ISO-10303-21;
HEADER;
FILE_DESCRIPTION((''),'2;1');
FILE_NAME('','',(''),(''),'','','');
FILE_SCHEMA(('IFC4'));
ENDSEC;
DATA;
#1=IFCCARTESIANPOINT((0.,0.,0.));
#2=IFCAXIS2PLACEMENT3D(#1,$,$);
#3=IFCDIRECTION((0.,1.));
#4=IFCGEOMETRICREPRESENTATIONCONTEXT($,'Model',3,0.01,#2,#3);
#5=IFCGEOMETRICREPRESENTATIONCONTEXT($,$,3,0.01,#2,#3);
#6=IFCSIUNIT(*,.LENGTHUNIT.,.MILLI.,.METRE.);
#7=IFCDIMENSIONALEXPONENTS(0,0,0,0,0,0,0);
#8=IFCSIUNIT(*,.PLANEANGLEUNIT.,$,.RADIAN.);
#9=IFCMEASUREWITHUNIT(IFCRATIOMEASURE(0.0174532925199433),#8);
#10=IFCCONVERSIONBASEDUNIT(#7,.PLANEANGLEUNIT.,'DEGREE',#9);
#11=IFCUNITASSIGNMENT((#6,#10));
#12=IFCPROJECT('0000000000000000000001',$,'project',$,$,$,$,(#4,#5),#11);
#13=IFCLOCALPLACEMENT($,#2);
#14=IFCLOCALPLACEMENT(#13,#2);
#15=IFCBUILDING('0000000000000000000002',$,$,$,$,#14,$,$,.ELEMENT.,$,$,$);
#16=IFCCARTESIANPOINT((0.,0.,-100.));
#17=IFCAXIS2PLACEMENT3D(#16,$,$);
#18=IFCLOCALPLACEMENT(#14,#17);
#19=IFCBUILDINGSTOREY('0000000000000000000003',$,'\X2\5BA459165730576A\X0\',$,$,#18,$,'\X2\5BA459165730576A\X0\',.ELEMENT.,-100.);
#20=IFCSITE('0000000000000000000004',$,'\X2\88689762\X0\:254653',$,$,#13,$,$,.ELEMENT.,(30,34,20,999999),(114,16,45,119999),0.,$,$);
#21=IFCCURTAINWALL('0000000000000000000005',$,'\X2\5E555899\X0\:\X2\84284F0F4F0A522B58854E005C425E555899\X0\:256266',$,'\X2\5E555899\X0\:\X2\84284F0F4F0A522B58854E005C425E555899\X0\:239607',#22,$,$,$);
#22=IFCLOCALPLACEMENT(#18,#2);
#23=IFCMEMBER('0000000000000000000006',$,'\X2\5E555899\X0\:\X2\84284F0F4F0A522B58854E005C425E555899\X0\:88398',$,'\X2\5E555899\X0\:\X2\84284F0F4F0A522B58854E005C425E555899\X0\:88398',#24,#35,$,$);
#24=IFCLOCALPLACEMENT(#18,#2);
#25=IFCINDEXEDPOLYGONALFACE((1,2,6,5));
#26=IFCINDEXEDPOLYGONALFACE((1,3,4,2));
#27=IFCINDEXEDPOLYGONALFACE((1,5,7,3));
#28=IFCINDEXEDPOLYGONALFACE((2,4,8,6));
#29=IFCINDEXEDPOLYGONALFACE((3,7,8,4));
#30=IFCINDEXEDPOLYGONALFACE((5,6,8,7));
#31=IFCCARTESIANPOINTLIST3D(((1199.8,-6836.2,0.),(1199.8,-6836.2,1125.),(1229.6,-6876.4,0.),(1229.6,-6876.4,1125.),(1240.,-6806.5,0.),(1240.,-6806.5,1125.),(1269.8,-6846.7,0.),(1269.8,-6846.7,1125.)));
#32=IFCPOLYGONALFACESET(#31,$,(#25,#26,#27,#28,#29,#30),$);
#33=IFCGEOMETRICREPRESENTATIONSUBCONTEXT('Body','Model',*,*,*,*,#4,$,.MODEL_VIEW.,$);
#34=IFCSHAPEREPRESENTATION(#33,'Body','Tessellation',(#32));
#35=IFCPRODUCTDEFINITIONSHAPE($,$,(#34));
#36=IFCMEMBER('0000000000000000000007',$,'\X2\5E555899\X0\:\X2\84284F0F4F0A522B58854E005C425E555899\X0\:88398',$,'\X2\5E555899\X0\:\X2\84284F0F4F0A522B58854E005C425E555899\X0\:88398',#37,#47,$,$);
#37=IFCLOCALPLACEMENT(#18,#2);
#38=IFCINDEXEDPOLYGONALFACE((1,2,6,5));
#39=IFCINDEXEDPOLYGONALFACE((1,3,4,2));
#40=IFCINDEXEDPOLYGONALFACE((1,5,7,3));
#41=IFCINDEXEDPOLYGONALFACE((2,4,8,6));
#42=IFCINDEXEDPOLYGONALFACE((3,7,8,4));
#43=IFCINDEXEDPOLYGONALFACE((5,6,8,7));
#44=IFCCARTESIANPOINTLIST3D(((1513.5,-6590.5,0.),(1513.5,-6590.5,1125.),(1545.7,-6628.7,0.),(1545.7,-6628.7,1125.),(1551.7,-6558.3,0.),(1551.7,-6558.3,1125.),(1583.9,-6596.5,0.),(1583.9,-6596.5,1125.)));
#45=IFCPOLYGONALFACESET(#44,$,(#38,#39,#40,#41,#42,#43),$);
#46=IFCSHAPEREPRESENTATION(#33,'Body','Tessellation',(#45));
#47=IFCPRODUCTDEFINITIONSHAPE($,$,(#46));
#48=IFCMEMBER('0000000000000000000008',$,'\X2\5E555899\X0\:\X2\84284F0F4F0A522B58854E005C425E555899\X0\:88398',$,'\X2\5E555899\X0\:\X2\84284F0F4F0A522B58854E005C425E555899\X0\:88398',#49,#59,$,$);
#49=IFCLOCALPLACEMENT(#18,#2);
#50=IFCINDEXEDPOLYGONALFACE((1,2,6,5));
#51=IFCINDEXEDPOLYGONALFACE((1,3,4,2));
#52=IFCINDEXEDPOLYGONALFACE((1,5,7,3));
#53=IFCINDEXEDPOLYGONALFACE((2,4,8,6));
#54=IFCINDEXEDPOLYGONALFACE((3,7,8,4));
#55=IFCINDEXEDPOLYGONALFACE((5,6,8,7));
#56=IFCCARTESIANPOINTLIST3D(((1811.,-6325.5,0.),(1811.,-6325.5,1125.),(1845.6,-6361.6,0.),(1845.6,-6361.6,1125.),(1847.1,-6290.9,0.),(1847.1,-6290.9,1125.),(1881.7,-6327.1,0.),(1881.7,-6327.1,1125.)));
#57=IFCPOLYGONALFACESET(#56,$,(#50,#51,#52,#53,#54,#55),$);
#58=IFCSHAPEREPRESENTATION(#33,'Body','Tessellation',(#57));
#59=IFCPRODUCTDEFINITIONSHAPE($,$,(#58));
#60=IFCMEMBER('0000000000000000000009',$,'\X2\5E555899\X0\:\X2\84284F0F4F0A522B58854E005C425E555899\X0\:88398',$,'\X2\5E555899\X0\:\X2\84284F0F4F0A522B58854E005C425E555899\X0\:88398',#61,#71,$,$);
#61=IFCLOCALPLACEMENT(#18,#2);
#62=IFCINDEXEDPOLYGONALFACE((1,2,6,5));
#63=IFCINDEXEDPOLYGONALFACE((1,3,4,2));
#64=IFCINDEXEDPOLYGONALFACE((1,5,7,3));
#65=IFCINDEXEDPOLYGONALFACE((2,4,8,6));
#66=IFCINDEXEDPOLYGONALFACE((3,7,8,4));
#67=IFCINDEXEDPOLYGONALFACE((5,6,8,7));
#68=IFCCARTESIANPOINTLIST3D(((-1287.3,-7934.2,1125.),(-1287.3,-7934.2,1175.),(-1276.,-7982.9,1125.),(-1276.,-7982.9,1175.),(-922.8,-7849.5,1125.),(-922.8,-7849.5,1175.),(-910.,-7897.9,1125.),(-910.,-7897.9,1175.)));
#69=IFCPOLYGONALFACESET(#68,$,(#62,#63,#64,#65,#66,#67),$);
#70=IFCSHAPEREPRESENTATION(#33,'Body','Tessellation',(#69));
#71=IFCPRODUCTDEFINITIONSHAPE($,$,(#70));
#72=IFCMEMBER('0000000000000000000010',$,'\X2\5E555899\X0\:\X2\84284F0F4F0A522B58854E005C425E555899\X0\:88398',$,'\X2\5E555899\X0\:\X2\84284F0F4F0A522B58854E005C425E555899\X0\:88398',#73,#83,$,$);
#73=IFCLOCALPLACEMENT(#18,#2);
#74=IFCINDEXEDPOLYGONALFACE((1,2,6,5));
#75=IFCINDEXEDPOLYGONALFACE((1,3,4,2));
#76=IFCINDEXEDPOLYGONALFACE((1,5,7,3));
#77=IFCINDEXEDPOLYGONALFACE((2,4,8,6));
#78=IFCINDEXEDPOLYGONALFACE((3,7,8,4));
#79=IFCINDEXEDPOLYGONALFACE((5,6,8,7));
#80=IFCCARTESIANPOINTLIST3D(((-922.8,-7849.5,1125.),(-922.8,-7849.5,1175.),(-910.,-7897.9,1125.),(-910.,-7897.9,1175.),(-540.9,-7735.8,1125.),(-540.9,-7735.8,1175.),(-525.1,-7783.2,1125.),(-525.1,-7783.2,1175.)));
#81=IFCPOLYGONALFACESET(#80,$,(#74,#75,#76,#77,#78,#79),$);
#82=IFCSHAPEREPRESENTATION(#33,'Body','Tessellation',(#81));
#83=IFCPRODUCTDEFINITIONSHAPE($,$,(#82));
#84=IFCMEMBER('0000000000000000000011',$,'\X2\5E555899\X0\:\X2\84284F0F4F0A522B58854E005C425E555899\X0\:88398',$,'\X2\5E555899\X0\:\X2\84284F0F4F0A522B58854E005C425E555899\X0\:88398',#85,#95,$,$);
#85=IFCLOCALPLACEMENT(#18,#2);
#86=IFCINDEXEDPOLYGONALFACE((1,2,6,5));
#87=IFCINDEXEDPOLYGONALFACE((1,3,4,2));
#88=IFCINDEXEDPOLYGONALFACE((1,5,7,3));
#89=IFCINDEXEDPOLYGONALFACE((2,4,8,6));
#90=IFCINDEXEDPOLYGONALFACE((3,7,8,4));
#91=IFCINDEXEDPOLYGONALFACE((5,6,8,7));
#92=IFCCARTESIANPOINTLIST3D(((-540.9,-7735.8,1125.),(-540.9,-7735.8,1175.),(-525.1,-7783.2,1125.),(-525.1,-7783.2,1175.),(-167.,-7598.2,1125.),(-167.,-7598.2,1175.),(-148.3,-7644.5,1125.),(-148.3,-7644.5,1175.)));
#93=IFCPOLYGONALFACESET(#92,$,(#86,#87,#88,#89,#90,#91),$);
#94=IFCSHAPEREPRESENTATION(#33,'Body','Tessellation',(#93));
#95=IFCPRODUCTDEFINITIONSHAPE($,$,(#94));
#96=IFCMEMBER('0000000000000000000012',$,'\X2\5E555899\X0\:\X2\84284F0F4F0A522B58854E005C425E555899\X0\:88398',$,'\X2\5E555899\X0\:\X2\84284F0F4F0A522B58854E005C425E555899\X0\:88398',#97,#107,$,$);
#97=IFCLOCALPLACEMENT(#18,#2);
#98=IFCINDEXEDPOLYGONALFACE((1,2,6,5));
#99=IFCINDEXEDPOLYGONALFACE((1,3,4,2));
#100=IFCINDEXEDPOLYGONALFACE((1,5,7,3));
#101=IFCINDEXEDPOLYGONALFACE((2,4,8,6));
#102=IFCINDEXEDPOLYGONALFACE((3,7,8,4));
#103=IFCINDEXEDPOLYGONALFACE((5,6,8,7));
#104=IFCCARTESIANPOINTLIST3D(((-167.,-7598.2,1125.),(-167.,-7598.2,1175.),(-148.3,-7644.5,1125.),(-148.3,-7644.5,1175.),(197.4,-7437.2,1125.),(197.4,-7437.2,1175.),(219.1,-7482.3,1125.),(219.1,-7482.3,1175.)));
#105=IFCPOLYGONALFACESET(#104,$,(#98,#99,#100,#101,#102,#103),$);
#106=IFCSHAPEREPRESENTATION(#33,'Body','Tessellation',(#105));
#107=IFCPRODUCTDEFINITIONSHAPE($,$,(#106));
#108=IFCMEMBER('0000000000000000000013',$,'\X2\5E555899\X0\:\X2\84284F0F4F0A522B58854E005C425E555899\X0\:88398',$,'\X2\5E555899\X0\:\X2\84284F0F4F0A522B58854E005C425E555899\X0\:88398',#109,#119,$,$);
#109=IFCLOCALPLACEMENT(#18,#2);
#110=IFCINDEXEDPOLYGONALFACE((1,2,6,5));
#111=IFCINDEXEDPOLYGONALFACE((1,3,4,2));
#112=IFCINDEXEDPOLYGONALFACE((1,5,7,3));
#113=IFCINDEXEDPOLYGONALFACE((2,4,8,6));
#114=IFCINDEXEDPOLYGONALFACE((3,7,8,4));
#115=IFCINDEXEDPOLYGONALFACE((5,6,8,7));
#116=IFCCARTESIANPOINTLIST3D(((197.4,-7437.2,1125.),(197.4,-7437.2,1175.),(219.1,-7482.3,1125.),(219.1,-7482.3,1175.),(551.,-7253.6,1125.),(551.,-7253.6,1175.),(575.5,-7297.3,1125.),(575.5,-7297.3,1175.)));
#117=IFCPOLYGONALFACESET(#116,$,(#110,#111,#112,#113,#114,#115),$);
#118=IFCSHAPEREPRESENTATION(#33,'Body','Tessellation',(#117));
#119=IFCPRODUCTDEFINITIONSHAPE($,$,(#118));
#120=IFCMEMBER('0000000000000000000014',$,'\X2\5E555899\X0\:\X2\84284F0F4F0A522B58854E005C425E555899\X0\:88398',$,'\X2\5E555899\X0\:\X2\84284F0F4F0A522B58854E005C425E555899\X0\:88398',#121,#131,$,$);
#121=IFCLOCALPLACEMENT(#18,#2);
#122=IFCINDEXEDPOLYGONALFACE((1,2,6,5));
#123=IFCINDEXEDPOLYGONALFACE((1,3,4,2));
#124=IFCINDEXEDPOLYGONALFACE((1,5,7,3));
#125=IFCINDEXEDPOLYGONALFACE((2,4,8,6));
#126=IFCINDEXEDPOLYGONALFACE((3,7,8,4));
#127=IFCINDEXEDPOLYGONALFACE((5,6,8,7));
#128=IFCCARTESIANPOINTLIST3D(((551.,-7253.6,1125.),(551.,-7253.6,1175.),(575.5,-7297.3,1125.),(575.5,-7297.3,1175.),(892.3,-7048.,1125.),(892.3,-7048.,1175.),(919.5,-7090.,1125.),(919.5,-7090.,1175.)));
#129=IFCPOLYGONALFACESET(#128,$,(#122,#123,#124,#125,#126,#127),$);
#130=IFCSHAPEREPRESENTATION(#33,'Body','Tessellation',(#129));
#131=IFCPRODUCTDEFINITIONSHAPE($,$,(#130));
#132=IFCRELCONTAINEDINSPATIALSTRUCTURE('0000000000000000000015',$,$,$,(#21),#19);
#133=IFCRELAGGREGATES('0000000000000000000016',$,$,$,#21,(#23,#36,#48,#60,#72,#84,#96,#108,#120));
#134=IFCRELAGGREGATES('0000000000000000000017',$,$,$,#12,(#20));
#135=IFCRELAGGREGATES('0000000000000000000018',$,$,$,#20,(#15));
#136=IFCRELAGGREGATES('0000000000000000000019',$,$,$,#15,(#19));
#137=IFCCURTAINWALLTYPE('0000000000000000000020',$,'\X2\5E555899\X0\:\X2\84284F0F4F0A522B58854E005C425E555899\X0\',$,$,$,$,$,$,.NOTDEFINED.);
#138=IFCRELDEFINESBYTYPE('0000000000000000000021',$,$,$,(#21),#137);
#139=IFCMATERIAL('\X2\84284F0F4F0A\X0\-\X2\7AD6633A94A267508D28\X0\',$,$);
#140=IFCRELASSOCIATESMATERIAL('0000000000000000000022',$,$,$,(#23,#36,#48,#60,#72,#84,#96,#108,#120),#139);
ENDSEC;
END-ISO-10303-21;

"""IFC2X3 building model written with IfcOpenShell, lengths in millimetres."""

from ifc_helpers import new_model, entity, si_unit, converted_unit, direction, frame, frame_2d, origin, origin_2d_with_axis, place, context, subcontext, project, spatial, rectangle, extrude, clip, halfspace, material, type_object, element, aggregate, save


model = new_model("IFC2X3")

# Units and contexts
model_context = context("Model", 3, precision=0.01, world=origin(), true_north=direction((0.0, 1.0)))
context_of_model = context(None, 3, precision=0.01, world=origin(), true_north=direction((0.0, 1.0)))
body_context = subcontext(model_context, "Body", "Model", "MODEL_VIEW")
ifc_project = project(units=[si_unit("LENGTHUNIT", "METRE", prefix="MILLI"), converted_unit("PLANEANGLEUNIT", "DEGREE", entity("IfcRatioMeasure", 0.0174532925199433), si_unit("PLANEANGLEUNIT", "RADIAN"), dimensions=[0, 0, 0, 0, 0, 0, 0])], contexts=[model_context, context_of_model])

# Site, building, storey
site_placement = place(None, origin())
site = spatial("IfcSite", under=ifc_project, at=site_placement, Name="表面:254653", CompositionType="ELEMENT", RefLatitude=(30, 34, 20, 999999), RefLongitude=(114, 16, 45, 119999), RefElevation=0.0)
building_placement = place(site_placement, origin())
building = spatial("IfcBuilding", under=site, at=building_placement, CompositionType="ELEMENT")
storey_placement = place(building_placement, frame((0.0, 0.0, -100.0)))
storey = spatial("IfcBuildingStorey", under=building, at=storey_placement, Name="室外地坪", LongName="室外地坪", CompositionType="ELEMENT", Elevation=-100.0)

# Curtain wall, members
curtain_wall_type = type_object("IfcCurtainWallType", Name="幕墙:萨伏伊别墅一层幕墙", PredefinedType="NOTDEFINED")
curtain_wall_placement = place(storey_placement, frame((0.0, 0.0, 100.0)))
curtain_wall = element("IfcCurtainWall", 1, at=curtain_wall_placement, inside=storey, type_object=curtain_wall_type, Name="幕墙:萨伏伊别墅一层幕墙:256266", ObjectType="幕墙:萨伏伊别墅一层幕墙:239607")
ifc_material_1 = material(Name="萨伏伊-竖挺钢材质")
member_1_placement = place(curtain_wall_placement, origin())
member_1 = element("IfcMember", 2, at=member_1_placement, material=ifc_material_1, Name="幕墙:萨伏伊别墅一层幕墙:88398", ObjectType="幕墙:萨伏伊别墅一层幕墙:88398", context=body_context, shape_type="SweptSolid", body=[
    extrude(rectangle(XDim=50.0, YDim=50.0, at=frame_2d((0.0, 0.0), x_axis=(1.0, 0.0))), frame((1234.8, -6841.4, -100.0), z_axis=(0.0, 0.0, 1.0), x_axis=(0.803942, 0.594708, 0.0)), (0.0, 0.0, 1.0), 1125.0),
])
member_2_placement = place(curtain_wall_placement, origin())
member_2 = element("IfcMember", 3, at=member_2_placement, material=ifc_material_1, Name="幕墙:萨伏伊别墅一层幕墙:88398", ObjectType="幕墙:萨伏伊别墅一层幕墙:88398", context=body_context, shape_type="SweptSolid", body=[
    extrude(rectangle(XDim=50.0, YDim=50.0, at=origin_2d_with_axis()), frame((1548.7, -6593.5, -100.0), z_axis=(0.0, 0.0, 1.0), x_axis=(0.764797, 0.644272, 0.0)), (0.0, 0.0, 1.0), 1125.0),
])
member_3_placement = place(curtain_wall_placement, origin())
member_3 = element("IfcMember", 4, at=member_3_placement, material=ifc_material_1, Name="幕墙:萨伏伊别墅一层幕墙:88398", ObjectType="幕墙:萨伏伊别墅一层幕墙:88398", context=body_context, shape_type="SweptSolid", body=[
    extrude(rectangle(XDim=50.0, YDim=50.0, at=frame_2d((0.0, 0.0), x_axis=(1.0, 0.0))), frame((1846.3, -6326.3, -100.0), z_axis=(0.0, 0.0, 1.0), x_axis=(0.722601, 0.691266, 0.0)), (0.0, 0.0, 1.0), 1125.0),
])
member_4_placement = place(curtain_wall_placement, frame((0.0, 0.0, -100.0)))
member_4 = element("IfcMember", 5, at=member_4_placement, material=ifc_material_1, Name="幕墙:萨伏伊别墅一层幕墙:88398", ObjectType="幕墙:萨伏伊别墅一层幕墙:88398", context=body_context, shape_type="Clipping", body=[
    clip(extrude(rectangle(XDim=50.0, YDim=50.0, at=origin_2d_with_axis()), frame((-915.7, -7873.5, 1150.0), z_axis=(-0.974057, -0.226305, 0.0), x_axis=(0.0, 0.0, -1.0)), (0.0, 0.0, 1.0), 375.8), halfspace(frame((-916.4, -7873.7, 1454.8), z_axis=(0.966677, 0.255997, 0.0), x_axis=(0.255997, -0.966677, 0.0)), False)),
])
member_5_placement = place(curtain_wall_placement, frame((0.0, 0.0, -100.0)))
member_5 = element("IfcMember", 6, at=member_5_placement, material=ifc_material_1, Name="幕墙:萨伏伊别墅一层幕墙:88398", ObjectType="幕墙:萨伏伊别墅一层幕墙:88398", context=body_context, shape_type="Clipping", body=[
    clip(clip(extrude(rectangle(XDim=50.0, YDim=50.0, at=frame_2d((0.0, 0.0), x_axis=(1.0, 0.0))), frame((-532.3, -7759.3, 1150.0), z_axis=(-0.958394, -0.28545, 0.0), x_axis=(0.0, 0.0, -1.0)), (0.0, 0.0, 1.0), 401.6), halfspace(frame((-533.0, -7759.5, 1454.8), z_axis=(0.948901, 0.315573, 0.0), x_axis=(0.315573, -0.948901, 0.0)), False)), halfspace(frame((-916.4, -7873.7, 1454.8), z_axis=(-0.966677, -0.255997, 0.0), x_axis=(0.255997, -0.966677, 0.0)), False)),
])
member_6_placement = place(curtain_wall_placement, frame((0.0, 0.0, -100.0)))
member_6 = element("IfcMember", 7, at=member_6_placement, material=ifc_material_1, Name="幕墙:萨伏伊别墅一层幕墙:88398", ObjectType="幕墙:萨伏伊别墅一层幕墙:88398", context=body_context, shape_type="Clipping", body=[
    clip(clip(extrude(rectangle(XDim=50.0, YDim=50.0, at=frame_2d((0.0, 0.0), x_axis=(1.0, 0.0))), frame((-156.9, -7621.1, 1150.0), z_axis=(-0.938463, -0.345381, 0.0), x_axis=(0.0, 0.0, -1.0)), (0.0, 0.0, 1.0), 401.6), halfspace(frame((-157.7, -7621.4, 1454.8), z_axis=(0.927088, 0.374844, 0.0), x_axis=(0.374844, -0.927088, 0.0)), False)), halfspace(frame((-533.0, -7759.5, 1454.8), z_axis=(-0.948901, -0.315573, 0.0), x_axis=(0.315573, -0.948901, 0.0)), False)),
])
member_7_placement = place(curtain_wall_placement, frame((0.0, 0.0, -100.0)))
member_7 = element("IfcMember", 8, at=member_7_placement, material=ifc_material_1, Name="幕墙:萨伏伊别墅一层幕墙:88398", ObjectType="幕墙:萨伏伊别墅一层幕墙:88398", context=body_context, shape_type="Clipping", body=[
    clip(clip(extrude(rectangle(XDim=50.0, YDim=50.0, at=frame_2d((0.0, 0.0), x_axis=(1.0, 0.0))), frame((209.0, -7459.5, 1150.0), z_axis=(-0.914788, -0.403934, 0.0), x_axis=(0.0, 0.0, -1.0)), (0.0, 0.0, 1.0), 401.6), halfspace(frame((208.3, -7459.8, 1454.8), z_axis=(0.901576, 0.43262, 0.0), x_axis=(0.43262, -0.901576, 0.0)), False)), halfspace(frame((-157.7, -7621.4, 1454.8), z_axis=(-0.927088, -0.374844, 0.0), x_axis=(0.374844, -0.927088, 0.0)), False)),
])
member_8_placement = place(curtain_wall_placement, frame((0.0, 0.0, -100.0)))
member_8 = element("IfcMember", 9, at=member_8_placement, material=ifc_material_1, Name="幕墙:萨伏伊别墅一层幕墙:88398", ObjectType="幕墙:萨伏伊别墅一层幕墙:88398", context=body_context, shape_type="Clipping", body=[
    clip(clip(extrude(rectangle(XDim=50.0, YDim=50.0, at=frame_2d((0.0, 0.0), x_axis=(1.0, 0.0))), frame((563.9, -7275.1, 1150.0), z_axis=(-0.887465, -0.460875, 0.0), x_axis=(0.0, 0.0, -1.0)), (0.0, 0.0, 1.0), 401.6), halfspace(frame((563.2, -7275.4, 1454.8), z_axis=(0.872468, 0.488671, 0.0), x_axis=(0.488671, -0.872468, 0.0)), False)), halfspace(frame((208.3, -7459.8, 1454.8), z_axis=(-0.901576, -0.43262, 0.0), x_axis=(0.43262, -0.901576, 0.0)), False)),
])
member_9_placement = place(curtain_wall_placement, frame((0.0, 0.0, -100.0)))
member_9 = element("IfcMember", 10, at=member_9_placement, material=ifc_material_1, Name="幕墙:萨伏伊别墅一层幕墙:88398", ObjectType="幕墙:萨伏伊别墅一层幕墙:88398", context=body_context, shape_type="Clipping", body=[
    clip(clip(extrude(rectangle(XDim=50.0, YDim=50.0, at=origin_2d_with_axis()), frame((906.6, -7068.6, 1150.0), z_axis=(-0.856601, -0.515979, 0.0), x_axis=(0.0, 0.0, -1.0)), (0.0, 0.0, 1.0), 401.6), halfspace(frame((905.9, -7069.0, 1454.8), z_axis=(0.83988, 0.542772, 0.0), x_axis=(0.542772, -0.83988, 0.0)), False)), halfspace(frame((563.2, -7275.4, 1454.8), z_axis=(-0.872468, -0.488671, 0.0), x_axis=(0.488671, -0.872468, 0.0)), False)),
])
aggregate(curtain_wall, [member_1, member_2, member_3, member_4, member_5, member_6, member_7, member_8, member_9])

save(model, "model.ifc")
